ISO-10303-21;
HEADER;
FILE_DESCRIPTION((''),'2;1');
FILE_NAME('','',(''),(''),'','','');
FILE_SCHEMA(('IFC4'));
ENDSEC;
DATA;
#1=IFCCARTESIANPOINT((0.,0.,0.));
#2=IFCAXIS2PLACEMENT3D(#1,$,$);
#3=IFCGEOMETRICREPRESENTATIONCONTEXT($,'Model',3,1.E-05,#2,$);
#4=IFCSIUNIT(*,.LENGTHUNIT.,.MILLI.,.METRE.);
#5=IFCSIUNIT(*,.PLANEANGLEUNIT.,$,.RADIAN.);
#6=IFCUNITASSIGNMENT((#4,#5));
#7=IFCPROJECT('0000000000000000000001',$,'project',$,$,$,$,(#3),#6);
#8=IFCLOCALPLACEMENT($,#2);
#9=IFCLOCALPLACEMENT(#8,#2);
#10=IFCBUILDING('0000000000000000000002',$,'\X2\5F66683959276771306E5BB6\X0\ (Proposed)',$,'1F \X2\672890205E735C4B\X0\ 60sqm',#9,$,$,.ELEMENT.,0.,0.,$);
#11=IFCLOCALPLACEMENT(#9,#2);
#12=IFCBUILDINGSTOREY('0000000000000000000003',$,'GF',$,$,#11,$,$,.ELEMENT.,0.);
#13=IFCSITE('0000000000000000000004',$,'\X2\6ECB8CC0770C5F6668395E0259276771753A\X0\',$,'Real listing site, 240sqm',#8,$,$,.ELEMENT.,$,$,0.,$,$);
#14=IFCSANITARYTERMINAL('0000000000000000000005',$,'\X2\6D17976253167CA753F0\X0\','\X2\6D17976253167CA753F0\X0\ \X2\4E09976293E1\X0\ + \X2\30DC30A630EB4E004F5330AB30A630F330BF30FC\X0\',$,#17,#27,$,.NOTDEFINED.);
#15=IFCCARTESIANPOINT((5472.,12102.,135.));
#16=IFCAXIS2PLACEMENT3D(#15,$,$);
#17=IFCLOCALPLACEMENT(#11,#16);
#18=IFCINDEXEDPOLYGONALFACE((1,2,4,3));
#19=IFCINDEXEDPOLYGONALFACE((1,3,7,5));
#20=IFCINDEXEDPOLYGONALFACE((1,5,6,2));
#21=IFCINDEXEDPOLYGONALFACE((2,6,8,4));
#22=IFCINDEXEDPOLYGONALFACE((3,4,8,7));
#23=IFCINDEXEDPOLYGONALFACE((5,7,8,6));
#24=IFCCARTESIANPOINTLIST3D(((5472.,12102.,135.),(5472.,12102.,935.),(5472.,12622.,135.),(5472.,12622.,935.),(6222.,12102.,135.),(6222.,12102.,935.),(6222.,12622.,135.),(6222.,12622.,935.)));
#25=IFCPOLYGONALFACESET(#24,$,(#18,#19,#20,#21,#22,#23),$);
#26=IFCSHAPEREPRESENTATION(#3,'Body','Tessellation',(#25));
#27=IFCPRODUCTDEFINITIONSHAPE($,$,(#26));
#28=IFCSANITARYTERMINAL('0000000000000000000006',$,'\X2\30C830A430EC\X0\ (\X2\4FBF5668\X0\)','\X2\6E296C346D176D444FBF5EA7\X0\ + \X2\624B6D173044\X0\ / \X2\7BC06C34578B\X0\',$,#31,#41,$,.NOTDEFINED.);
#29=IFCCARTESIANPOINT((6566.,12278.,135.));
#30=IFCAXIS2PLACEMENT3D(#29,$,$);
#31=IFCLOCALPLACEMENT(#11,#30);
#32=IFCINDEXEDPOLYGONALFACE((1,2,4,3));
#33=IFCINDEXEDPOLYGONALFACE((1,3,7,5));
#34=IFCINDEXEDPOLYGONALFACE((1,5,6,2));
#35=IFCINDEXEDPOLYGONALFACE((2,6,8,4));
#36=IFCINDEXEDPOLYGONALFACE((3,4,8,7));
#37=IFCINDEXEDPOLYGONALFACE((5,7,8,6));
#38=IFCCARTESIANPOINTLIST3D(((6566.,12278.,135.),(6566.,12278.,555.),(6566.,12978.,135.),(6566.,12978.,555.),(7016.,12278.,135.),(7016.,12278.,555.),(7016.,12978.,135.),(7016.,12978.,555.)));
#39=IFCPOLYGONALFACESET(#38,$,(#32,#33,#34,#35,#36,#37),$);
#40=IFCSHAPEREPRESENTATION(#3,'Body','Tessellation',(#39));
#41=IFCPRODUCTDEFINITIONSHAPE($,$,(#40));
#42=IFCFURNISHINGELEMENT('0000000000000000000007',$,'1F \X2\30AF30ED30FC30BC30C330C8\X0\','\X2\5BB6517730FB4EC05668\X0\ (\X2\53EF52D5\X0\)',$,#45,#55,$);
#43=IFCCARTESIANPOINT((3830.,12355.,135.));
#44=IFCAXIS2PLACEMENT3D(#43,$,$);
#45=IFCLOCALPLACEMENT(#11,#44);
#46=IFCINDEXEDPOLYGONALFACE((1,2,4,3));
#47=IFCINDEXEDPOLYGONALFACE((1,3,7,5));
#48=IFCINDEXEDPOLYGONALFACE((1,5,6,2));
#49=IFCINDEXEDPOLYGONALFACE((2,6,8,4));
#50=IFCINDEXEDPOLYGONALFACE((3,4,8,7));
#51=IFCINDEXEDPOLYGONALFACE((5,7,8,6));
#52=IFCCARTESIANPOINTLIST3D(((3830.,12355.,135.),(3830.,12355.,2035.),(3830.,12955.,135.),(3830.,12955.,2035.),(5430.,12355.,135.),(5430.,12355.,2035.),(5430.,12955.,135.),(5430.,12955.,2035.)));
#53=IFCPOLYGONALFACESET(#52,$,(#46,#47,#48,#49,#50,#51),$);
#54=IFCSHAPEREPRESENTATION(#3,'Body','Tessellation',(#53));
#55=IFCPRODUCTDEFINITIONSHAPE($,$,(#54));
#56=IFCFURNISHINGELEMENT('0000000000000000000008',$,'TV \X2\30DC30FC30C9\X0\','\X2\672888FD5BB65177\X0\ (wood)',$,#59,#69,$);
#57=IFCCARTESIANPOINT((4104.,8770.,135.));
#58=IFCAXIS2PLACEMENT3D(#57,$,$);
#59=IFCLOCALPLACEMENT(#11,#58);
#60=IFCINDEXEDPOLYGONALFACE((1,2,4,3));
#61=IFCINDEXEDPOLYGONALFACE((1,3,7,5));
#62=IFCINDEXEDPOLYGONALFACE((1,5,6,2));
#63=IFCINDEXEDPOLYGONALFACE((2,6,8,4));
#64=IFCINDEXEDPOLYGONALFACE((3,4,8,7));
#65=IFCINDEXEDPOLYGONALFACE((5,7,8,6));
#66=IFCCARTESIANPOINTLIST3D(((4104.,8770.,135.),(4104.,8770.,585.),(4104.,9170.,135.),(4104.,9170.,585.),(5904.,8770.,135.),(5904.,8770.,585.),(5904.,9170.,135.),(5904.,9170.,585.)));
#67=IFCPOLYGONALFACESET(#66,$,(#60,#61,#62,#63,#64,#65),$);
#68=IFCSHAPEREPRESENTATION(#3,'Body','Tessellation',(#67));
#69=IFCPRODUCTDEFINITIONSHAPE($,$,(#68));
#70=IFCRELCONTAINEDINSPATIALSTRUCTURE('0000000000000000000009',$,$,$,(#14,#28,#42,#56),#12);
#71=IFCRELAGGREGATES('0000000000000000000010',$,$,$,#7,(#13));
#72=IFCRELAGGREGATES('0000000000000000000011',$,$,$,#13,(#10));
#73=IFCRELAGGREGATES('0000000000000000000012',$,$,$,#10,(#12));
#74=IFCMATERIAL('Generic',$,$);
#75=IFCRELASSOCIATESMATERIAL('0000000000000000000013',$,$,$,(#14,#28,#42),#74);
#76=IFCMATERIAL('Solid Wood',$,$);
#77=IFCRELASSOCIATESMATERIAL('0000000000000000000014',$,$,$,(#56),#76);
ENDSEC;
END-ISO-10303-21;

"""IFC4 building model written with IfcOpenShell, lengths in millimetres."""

from ifc_helpers import new_model, si_unit, frame, frame_2d, origin, place, context, project, spatial, rectangle, extrude, material, element, save


model = new_model("IFC4")

# Units and contexts
model_context = context("Model", 3, precision=1e-05, world=origin())
ifc_project = project(units=[si_unit("LENGTHUNIT", "METRE", prefix="MILLI"), si_unit("PLANEANGLEUNIT", "RADIAN")], contexts=[model_context])

# Site, building, storey
site_placement = place(None, origin())
site = spatial("IfcSite", under=ifc_project, at=site_placement, Name="滋賀県彦根市大東町", ObjectType="Real listing site, 240sqm", CompositionType="ELEMENT", RefElevation=0.0)
building_placement = place(site_placement, origin())
building = spatial("IfcBuilding", under=site, at=building_placement, Name="彦根大東の家 (Proposed)", ObjectType="1F 木造平屋 60sqm", CompositionType="ELEMENT", ElevationOfRefHeight=0.0, ElevationOfTerrain=0.0)
storey_placement = place(building_placement, origin())
storey = spatial("IfcBuildingStorey", under=building, at=storey_placement, Name="GF", CompositionType="ELEMENT", Elevation=0.0)

# Shared definitions
ifc_material_1 = material(Name="Solid Wood")

# Shared definitions
ifc_material_2 = material(Name="Generic")

# Sanitary terminals
sanitary_terminal_1_placement = place(storey_placement, frame((5472.0, 12102.0, 135.0)))
element("IfcSanitaryTerminal", 1, at=sanitary_terminal_1_placement, inside=storey, material=ifc_material_2, Name="洗面化粧台", Description="洗面化粧台 三面鏡 + ボウル一体カウンター", PredefinedType="NOTDEFINED", context=model_context, shape_type="SweptSolid", body=[
    extrude(rectangle(XDim=750.0, YDim=520.0, at=frame_2d((375.0, 260.0))), frame((5472.0, 12102.0, 135.0)), (0.0, 0.0, 1.0), 800.0),
])
sanitary_terminal_2_placement = place(storey_placement, frame((6566.0, 12278.0, 135.0)))
element("IfcSanitaryTerminal", 2, at=sanitary_terminal_2_placement, inside=storey, material=ifc_material_2, Name="トイレ (便器)", Description="温水洗浄便座 + 手洗い / 節水型", PredefinedType="NOTDEFINED", context=model_context, shape_type="SweptSolid", body=[
    extrude(rectangle(XDim=450.0, YDim=700.0, at=frame_2d((225.0, 350.0))), frame((6566.0, 12278.0, 135.0)), (0.0, 0.0, 1.0), 420.0),
])

# Furnishing elements
furnishing_1_placement = place(storey_placement, frame((3830.0, 12355.0, 135.0)))
element("IfcFurnishingElement", 3, at=furnishing_1_placement, inside=storey, material=ifc_material_2, Name="1F クローゼット", Description="家具・什器 (可動)", context=model_context, shape_type="SweptSolid", body=[
    extrude(rectangle(XDim=1600.0, YDim=600.0, at=frame_2d((800.0, 300.0))), frame((3830.0, 12355.0, 135.0)), (0.0, 0.0, 1.0), 1900.0),
])
furnishing_2_placement = place(storey_placement, frame((4104.0, 8770.0, 135.0)))
element("IfcFurnishingElement", 4, at=furnishing_2_placement, inside=storey, material=ifc_material_1, Name="TV ボード", Description="木製家具 (wood)", context=model_context, shape_type="SweptSolid", body=[
    extrude(rectangle(XDim=1800.0, YDim=400.0, at=frame_2d((900.0, 200.0))), frame((4104.0, 8770.0, 135.0)), (0.0, 0.0, 1.0), 450.0),
])

save(model, "model.ifc")
